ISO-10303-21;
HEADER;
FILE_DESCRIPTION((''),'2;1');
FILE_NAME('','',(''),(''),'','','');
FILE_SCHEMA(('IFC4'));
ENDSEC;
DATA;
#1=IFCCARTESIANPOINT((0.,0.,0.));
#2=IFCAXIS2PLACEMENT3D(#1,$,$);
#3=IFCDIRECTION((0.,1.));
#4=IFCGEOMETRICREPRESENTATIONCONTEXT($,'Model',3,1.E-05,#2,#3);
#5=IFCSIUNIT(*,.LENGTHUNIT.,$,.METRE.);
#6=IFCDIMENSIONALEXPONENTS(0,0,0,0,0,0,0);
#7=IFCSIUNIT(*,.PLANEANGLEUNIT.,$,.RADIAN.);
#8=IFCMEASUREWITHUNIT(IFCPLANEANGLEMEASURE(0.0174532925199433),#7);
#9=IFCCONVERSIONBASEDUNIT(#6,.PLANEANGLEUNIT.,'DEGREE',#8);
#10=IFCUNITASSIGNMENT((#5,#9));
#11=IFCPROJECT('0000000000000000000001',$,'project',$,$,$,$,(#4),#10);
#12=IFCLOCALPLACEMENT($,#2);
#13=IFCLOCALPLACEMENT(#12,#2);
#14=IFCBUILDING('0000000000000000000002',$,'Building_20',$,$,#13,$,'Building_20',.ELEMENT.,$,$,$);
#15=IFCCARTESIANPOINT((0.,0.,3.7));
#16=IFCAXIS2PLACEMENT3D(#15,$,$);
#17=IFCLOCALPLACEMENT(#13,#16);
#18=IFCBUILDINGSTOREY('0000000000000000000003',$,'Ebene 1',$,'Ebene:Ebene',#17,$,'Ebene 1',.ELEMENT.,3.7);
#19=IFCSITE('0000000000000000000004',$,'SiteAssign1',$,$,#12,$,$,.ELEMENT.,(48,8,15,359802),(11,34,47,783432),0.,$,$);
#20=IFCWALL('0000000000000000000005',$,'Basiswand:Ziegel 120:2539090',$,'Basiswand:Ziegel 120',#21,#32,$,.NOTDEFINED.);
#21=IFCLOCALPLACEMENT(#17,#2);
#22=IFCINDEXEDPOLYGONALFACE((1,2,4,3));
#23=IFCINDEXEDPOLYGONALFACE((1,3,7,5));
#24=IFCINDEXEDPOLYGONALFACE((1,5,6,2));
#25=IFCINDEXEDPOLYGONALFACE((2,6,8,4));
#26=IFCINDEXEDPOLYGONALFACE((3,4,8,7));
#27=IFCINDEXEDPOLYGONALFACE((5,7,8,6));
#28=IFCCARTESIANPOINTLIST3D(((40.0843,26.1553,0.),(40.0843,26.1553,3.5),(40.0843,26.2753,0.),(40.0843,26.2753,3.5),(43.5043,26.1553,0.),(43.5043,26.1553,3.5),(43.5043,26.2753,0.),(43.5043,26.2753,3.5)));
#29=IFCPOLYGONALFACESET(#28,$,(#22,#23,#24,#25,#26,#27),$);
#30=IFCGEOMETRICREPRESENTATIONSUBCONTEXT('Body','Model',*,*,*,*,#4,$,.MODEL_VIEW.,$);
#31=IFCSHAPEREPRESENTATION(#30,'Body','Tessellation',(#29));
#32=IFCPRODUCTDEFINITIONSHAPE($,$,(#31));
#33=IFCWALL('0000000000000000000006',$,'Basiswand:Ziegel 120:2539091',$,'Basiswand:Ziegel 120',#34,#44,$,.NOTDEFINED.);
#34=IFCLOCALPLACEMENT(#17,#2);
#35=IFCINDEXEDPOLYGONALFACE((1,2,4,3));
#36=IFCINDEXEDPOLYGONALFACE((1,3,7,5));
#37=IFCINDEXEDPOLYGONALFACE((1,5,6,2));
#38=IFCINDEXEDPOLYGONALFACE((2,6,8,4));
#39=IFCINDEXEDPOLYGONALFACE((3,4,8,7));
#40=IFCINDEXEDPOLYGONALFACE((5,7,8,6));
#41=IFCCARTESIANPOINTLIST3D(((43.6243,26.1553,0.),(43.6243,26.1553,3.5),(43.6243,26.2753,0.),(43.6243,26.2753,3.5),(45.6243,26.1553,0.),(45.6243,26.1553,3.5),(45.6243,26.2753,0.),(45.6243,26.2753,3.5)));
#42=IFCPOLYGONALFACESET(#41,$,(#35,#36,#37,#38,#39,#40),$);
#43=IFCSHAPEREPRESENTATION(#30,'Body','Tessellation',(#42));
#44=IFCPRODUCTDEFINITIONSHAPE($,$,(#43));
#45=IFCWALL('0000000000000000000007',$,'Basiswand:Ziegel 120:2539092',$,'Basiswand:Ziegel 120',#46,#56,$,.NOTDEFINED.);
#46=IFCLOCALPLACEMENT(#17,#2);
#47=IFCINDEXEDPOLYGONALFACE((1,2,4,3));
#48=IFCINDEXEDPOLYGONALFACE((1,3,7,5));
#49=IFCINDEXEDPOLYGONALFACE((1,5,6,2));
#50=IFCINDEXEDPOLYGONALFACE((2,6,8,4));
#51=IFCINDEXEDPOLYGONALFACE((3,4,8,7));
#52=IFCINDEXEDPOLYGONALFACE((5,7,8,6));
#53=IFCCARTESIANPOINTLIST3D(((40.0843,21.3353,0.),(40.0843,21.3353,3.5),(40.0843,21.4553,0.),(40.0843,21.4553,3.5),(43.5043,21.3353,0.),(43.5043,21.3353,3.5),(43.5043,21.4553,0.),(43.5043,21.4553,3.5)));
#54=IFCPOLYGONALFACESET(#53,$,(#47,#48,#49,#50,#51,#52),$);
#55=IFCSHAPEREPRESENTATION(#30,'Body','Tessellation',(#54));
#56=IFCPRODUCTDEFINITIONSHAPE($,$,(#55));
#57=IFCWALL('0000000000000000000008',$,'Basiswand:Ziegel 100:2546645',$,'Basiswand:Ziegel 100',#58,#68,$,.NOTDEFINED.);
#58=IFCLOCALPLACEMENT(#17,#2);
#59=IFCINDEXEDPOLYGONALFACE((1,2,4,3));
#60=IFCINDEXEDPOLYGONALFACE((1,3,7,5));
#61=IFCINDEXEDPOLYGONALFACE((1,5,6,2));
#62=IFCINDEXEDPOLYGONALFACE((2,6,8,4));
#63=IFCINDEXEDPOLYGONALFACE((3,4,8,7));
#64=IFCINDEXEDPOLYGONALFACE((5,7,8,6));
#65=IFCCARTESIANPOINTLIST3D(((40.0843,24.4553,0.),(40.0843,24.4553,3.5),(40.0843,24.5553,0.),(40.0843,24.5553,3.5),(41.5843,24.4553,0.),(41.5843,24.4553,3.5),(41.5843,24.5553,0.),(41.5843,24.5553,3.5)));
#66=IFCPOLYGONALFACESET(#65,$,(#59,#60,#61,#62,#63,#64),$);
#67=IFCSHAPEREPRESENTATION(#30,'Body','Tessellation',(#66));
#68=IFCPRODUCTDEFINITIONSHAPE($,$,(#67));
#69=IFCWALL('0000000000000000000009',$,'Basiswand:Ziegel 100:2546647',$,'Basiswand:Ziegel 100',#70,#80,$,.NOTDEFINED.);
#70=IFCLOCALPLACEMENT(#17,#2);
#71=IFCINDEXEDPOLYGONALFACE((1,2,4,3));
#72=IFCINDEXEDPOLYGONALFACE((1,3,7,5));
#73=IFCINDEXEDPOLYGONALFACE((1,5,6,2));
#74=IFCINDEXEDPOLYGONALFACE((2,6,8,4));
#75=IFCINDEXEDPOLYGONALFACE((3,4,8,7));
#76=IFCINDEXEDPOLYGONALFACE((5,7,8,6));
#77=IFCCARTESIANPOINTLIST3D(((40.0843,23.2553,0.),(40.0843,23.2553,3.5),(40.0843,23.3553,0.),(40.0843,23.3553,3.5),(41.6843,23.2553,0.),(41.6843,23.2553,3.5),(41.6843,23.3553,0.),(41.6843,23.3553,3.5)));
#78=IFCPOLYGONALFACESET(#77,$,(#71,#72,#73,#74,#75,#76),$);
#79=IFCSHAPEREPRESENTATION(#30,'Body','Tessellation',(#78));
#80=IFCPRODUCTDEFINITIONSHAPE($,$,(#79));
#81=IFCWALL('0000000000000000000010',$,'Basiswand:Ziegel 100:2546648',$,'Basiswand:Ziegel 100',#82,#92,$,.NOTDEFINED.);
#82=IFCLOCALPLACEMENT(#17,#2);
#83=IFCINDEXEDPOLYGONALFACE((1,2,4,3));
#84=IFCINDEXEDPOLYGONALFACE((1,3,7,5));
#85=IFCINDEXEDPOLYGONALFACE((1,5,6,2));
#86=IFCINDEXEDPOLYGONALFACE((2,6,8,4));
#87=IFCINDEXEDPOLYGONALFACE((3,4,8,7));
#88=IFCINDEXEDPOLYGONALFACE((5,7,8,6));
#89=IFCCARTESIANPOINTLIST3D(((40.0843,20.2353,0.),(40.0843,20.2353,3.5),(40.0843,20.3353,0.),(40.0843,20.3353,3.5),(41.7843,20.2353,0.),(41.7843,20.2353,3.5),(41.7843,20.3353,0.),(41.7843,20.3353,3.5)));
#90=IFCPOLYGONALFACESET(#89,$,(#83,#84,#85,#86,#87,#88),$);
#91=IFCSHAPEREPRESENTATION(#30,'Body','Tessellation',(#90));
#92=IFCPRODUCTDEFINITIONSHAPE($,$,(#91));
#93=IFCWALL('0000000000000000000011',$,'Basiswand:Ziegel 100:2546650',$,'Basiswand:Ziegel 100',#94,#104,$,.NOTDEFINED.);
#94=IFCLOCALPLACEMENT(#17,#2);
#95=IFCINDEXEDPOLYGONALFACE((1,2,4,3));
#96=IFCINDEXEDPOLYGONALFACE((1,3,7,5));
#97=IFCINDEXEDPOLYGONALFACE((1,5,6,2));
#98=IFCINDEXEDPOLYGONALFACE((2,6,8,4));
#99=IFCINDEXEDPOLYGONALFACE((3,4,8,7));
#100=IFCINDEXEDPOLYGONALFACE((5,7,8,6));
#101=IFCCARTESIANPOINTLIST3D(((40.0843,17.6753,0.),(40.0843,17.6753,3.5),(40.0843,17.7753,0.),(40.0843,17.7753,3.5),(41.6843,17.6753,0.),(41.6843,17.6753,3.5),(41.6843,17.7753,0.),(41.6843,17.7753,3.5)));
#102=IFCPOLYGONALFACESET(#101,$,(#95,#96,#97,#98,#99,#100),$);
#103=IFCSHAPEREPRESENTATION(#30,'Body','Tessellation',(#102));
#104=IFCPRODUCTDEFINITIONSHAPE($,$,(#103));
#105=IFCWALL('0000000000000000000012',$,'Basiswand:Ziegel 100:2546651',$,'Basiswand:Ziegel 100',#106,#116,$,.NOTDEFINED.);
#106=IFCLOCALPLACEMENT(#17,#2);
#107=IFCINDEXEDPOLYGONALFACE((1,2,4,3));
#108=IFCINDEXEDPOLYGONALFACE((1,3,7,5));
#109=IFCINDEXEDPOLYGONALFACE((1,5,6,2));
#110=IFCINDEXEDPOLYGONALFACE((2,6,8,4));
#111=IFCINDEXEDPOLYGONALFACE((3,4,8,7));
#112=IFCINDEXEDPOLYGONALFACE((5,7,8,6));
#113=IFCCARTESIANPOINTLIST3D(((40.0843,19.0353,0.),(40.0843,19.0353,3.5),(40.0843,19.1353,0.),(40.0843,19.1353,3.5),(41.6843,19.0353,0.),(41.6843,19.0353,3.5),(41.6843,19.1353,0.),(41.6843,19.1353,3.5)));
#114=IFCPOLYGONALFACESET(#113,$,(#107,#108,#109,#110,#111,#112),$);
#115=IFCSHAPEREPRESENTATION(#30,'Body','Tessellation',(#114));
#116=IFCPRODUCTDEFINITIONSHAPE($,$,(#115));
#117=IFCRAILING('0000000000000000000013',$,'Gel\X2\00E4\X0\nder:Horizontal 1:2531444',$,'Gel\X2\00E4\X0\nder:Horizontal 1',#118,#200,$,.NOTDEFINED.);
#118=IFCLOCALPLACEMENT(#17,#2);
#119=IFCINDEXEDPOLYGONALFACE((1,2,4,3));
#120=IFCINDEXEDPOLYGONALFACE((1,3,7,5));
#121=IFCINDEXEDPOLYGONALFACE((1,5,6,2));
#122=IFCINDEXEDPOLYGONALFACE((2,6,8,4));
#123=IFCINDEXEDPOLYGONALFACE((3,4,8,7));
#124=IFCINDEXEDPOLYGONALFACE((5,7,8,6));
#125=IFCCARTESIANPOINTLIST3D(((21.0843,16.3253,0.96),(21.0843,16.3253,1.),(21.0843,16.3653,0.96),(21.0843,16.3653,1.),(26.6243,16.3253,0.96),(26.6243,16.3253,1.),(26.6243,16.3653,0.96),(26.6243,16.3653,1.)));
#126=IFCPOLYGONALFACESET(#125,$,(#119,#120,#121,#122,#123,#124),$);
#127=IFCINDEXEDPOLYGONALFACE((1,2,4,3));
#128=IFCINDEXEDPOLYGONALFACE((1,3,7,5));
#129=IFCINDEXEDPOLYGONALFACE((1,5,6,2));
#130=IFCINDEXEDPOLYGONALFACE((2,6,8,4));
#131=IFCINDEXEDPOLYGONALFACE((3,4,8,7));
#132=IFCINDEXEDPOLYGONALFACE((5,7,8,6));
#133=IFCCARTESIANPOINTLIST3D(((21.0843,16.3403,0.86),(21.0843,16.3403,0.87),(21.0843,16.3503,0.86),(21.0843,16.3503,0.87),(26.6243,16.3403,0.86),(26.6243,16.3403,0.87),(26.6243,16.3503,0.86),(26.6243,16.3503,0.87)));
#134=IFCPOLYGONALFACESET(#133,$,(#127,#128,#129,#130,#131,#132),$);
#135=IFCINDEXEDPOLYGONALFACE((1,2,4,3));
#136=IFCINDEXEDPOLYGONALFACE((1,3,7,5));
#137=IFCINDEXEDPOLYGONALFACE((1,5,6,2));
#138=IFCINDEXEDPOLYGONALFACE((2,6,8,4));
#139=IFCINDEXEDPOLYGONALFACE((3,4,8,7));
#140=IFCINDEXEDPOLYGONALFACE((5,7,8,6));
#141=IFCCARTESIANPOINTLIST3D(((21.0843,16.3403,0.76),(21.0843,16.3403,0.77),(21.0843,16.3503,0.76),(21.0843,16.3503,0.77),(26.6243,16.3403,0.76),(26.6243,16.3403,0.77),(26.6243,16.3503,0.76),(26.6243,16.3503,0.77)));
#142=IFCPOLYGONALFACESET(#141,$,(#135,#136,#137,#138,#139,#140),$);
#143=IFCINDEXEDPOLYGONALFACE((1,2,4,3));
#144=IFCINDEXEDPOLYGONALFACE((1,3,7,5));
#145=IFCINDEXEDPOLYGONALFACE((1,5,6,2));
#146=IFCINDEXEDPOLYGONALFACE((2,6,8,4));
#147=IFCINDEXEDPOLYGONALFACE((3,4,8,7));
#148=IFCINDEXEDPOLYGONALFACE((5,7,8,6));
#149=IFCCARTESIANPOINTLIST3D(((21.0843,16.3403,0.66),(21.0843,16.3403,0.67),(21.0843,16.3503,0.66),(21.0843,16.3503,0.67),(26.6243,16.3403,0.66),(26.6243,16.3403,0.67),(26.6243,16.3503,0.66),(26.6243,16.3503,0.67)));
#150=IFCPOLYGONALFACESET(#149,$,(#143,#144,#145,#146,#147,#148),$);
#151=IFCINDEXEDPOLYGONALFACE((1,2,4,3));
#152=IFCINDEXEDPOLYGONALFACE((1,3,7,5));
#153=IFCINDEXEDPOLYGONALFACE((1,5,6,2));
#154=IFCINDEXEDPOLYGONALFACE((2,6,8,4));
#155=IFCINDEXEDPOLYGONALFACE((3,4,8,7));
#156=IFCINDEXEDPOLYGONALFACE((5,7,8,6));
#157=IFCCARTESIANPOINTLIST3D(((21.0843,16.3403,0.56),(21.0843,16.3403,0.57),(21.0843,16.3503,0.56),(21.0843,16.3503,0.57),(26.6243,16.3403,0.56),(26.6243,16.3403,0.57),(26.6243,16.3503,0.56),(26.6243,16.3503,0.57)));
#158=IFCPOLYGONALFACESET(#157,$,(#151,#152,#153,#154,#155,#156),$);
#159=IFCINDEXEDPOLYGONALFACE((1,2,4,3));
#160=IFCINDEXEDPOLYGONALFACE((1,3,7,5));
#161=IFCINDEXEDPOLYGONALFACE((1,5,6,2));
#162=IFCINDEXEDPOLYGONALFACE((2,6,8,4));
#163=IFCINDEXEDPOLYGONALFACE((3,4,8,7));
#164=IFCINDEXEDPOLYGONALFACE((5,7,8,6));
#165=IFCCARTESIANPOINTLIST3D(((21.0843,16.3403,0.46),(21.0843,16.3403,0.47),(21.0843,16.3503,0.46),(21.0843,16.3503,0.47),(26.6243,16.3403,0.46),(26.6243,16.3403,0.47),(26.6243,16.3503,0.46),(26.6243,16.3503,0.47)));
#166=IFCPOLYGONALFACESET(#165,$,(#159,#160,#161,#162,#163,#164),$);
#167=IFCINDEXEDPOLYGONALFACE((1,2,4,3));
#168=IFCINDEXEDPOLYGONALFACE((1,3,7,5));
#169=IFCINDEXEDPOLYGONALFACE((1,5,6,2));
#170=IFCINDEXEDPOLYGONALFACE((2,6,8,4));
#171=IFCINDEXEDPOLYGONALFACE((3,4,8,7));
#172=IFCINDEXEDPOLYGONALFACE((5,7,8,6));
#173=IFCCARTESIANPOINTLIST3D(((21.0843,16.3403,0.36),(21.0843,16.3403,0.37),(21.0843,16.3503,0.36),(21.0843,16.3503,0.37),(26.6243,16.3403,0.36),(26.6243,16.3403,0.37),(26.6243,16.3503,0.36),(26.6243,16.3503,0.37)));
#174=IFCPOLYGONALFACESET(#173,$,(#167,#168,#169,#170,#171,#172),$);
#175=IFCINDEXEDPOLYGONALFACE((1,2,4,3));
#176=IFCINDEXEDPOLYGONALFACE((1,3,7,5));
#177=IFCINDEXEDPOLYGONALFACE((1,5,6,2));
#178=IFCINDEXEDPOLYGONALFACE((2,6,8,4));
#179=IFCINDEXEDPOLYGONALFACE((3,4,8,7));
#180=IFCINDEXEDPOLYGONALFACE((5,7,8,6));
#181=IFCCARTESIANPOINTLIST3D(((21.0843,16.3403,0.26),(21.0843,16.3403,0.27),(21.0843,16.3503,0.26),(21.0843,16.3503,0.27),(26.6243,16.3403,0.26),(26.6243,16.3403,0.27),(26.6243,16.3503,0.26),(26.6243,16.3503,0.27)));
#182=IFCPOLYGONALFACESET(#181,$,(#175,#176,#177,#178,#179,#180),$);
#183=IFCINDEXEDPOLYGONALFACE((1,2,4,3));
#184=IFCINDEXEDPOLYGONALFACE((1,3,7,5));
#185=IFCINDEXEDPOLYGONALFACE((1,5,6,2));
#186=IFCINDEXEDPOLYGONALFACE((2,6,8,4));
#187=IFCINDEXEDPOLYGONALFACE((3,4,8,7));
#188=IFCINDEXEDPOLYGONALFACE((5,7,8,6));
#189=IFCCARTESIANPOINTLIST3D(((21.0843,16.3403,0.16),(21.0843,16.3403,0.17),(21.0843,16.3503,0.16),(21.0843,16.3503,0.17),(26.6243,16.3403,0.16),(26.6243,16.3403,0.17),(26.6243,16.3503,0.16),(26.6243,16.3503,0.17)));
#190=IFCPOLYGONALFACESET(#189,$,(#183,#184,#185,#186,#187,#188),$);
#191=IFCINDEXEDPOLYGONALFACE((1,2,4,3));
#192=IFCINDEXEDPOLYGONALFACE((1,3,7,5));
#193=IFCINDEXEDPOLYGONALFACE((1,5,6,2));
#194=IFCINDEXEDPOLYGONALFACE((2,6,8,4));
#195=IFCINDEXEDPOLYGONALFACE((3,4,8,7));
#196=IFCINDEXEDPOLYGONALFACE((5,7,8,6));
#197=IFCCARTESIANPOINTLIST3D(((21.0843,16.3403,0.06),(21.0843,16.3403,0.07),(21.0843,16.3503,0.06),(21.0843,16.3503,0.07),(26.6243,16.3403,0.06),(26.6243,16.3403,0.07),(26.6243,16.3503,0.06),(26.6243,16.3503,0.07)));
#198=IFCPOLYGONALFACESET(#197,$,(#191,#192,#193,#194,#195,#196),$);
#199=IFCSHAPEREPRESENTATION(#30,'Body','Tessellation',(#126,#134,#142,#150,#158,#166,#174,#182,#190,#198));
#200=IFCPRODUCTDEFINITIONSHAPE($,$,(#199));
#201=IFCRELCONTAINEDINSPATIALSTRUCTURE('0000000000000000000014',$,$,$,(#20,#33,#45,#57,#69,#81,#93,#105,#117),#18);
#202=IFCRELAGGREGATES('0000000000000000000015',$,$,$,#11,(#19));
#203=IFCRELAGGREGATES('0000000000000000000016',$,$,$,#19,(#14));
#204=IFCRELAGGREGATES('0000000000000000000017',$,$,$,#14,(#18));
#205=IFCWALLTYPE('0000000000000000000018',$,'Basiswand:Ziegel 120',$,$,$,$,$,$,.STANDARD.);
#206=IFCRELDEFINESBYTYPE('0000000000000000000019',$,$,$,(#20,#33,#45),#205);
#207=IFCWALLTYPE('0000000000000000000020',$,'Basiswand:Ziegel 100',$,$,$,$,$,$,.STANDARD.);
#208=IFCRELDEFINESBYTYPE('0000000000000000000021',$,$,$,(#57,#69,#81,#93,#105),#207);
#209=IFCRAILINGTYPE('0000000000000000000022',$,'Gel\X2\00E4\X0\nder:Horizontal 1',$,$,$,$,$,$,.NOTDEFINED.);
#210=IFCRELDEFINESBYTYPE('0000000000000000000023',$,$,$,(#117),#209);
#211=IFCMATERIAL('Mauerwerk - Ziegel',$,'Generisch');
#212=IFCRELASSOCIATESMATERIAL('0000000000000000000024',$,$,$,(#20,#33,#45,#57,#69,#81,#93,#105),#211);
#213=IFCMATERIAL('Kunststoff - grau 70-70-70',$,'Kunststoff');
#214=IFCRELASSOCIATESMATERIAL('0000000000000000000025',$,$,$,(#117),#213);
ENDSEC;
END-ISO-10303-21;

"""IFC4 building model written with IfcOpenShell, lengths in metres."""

from ifc_helpers import new_model, entity, si_unit, converted_unit, direction, frame, origin, place, context, subcontext, project, spatial, indexed_curve, outline, extrude, material, type_object, element, save


model = new_model("IFC4")

# Units and contexts
model_context = context("Model", 3, precision=1e-05, world=origin(), true_north=direction((0.0, 1.0)))
body_context = subcontext(model_context, "Body", "Model", "MODEL_VIEW")
ifc_project = project(units=[si_unit("LENGTHUNIT", "METRE"), converted_unit("PLANEANGLEUNIT", "DEGREE", entity("IfcPlaneAngleMeasure", 0.0174532925199433), si_unit("PLANEANGLEUNIT", "RADIAN"), dimensions=[0, 0, 0, 0, 0, 0, 0])], contexts=[model_context])

# Site, building, storey
site_placement = place(None, origin())
site = spatial("IfcSite", under=ifc_project, at=site_placement, Name="SiteAssign1", CompositionType="ELEMENT", RefLatitude=(48, 8, 15, 359802), RefLongitude=(11, 34, 47, 783432), RefElevation=0.0)
building_placement = place(site_placement, origin())
building = spatial("IfcBuilding", under=site, at=building_placement, Name="Building_20", LongName="Building_20", CompositionType="ELEMENT")
storey_placement = place(building_placement, frame((0.0, 0.0, 3.7)))
storey = spatial("IfcBuildingStorey", under=building, at=storey_placement, Name="Ebene 1", ObjectType="Ebene:Ebene", LongName="Ebene 1", CompositionType="ELEMENT", Elevation=3.7)

# Shared definitions
ifc_material_1 = material(Name="Mauerwerk - Ziegel", Category="Generisch")

# Walls
wall_type_1 = type_object("IfcWallType", Name="Basiswand:Ziegel 120", PredefinedType="STANDARD")
wall_1_placement = place(storey_placement, frame((43.5043, 26.2153, 0.0), z_axis=(0.0, 0.0, 1.0), x_axis=(-1.0, 0.0, 0.0)))
element("IfcWall", 1, at=wall_1_placement, inside=storey, type_object=wall_type_1, material=ifc_material_1, Name="Basiswand:Ziegel 120:2539090", ObjectType="Basiswand:Ziegel 120", PredefinedType="NOTDEFINED", context=body_context, shape_type="SweptSolid", body=[
    extrude(outline(indexed_curve([(3.42, 0.06), (0.0, 0.06), (0.0, -0.06), (3.42, -0.06), (3.42, 0.06)], self_intersect=False)), origin(), (0.0, 0.0, 1.0), 3.5),
])
wall_2_placement = place(storey_placement, frame((43.6243, 26.2153, 0.0)))
element("IfcWall", 2, at=wall_2_placement, inside=storey, type_object=wall_type_1, material=ifc_material_1, Name="Basiswand:Ziegel 120:2539091", ObjectType="Basiswand:Ziegel 120", PredefinedType="NOTDEFINED", context=body_context, shape_type="SweptSolid", body=[
    extrude(outline(indexed_curve([(2.0, 0.06), (0.0, 0.06), (0.0, -0.06), (2.0, -0.06), (2.0, 0.06)], self_intersect=False)), origin(), (0.0, 0.0, 1.0), 3.5),
])
wall_3_placement = place(storey_placement, frame((43.5043, 21.3953, 0.0), z_axis=(0.0, 0.0, 1.0), x_axis=(-1.0, 0.0, 0.0)))
element("IfcWall", 3, at=wall_3_placement, inside=storey, type_object=wall_type_1, material=ifc_material_1, Name="Basiswand:Ziegel 120:2539092", ObjectType="Basiswand:Ziegel 120", PredefinedType="NOTDEFINED", context=body_context, shape_type="SweptSolid", body=[
    extrude(outline(indexed_curve([(3.42, 0.06), (0.0, 0.06), (0.0, -0.06), (3.42, -0.06), (3.42, 0.06)], self_intersect=False)), origin(), (0.0, 0.0, 1.0), 3.5),
])
wall_type_2 = type_object("IfcWallType", Name="Basiswand:Ziegel 100", PredefinedType="STANDARD")
wall_4_placement = place(storey_placement, frame((40.0843, 24.5053, 0.0)))
element("IfcWall", 4, at=wall_4_placement, inside=storey, type_object=wall_type_2, material=ifc_material_1, Name="Basiswand:Ziegel 100:2546645", ObjectType="Basiswand:Ziegel 100", PredefinedType="NOTDEFINED", context=body_context, shape_type="SweptSolid", body=[
    extrude(outline(indexed_curve([(1.5, 0.05), (0.0, 0.05), (0.0, -0.05), (1.5, -0.05), (1.5, 0.05)], self_intersect=False)), origin(), (0.0, 0.0, 1.0), 3.5),
])
wall_5_placement = place(storey_placement, frame((40.0843, 23.3053, 0.0)))
element("IfcWall", 5, at=wall_5_placement, inside=storey, type_object=wall_type_2, material=ifc_material_1, Name="Basiswand:Ziegel 100:2546647", ObjectType="Basiswand:Ziegel 100", PredefinedType="NOTDEFINED", context=body_context, shape_type="SweptSolid", body=[
    extrude(outline(indexed_curve([(1.6, 0.05), (0.0, 0.05), (0.0, -0.05), (1.6, -0.05), (1.6, 0.05)], self_intersect=False)), origin(), (0.0, 0.0, 1.0), 3.5),
])
wall_6_placement = place(storey_placement, frame((40.0843, 20.2853, 0.0)))
element("IfcWall", 6, at=wall_6_placement, inside=storey, type_object=wall_type_2, material=ifc_material_1, Name="Basiswand:Ziegel 100:2546648", ObjectType="Basiswand:Ziegel 100", PredefinedType="NOTDEFINED", context=body_context, shape_type="SweptSolid", body=[
    extrude(outline(indexed_curve([(1.7, 0.05), (0.0, 0.05), (0.0, -0.05), (1.7, -0.05), (1.7, 0.05)], self_intersect=False)), origin(), (0.0, 0.0, 1.0), 3.5),
])
for number, where, name in (
    (7, (40.0843, 17.7253, 0.0), "Basiswand:Ziegel 100:2546650"),
    (8, (40.0843, 19.0853, 0.0), "Basiswand:Ziegel 100:2546651"),
):
    element("IfcWall", number, at=place(storey_placement, frame(where)), inside=storey, type_object=wall_type_2, material=ifc_material_1, Name=name, ObjectType="Basiswand:Ziegel 100", PredefinedType="NOTDEFINED", context=body_context, shape_type="SweptSolid", body=[
        extrude(outline(indexed_curve([(1.6, 0.05), (0.0, 0.05), (0.0, -0.05), (1.6, -0.05), (1.6, 0.05)], self_intersect=False)), origin(), (0.0, 0.0, 1.0), 3.5),
    ])

# Railing
ifc_material_2 = material(Name="Kunststoff - grau 70-70-70", Category="Kunststoff")
railing_type = type_object("IfcRailingType", Name="Geländer:Horizontal 1", PredefinedType="NOTDEFINED")
railing_placement = place(storey_placement, origin())
element("IfcRailing", 9, at=railing_placement, inside=storey, type_object=railing_type, material=ifc_material_2, Name="Geländer:Horizontal 1:2531444", ObjectType="Geländer:Horizontal 1", PredefinedType="NOTDEFINED", context=body_context, shape_type="SweptSolid", body=[
    extrude(outline(indexed_curve([(-2.77, -0.02), (2.77, -0.02), (2.77, 0.02), (-2.77, 0.02), (-2.77, -0.02)], self_intersect=False)), frame((23.8543, 16.3453, 0.96)), (0.0, 0.0, 1.0), 0.04),
    extrude(outline(indexed_curve([(-2.77, -0.005), (2.77, -0.005), (2.77, 0.005), (-2.77, 0.005), (-2.77, -0.005)], self_intersect=False)), frame((23.8543, 16.3453, 0.86)), (0.0, 0.0, 1.0), 0.01),
    extrude(outline(indexed_curve([(-2.77, -0.005), (2.77, -0.005), (2.77, 0.005), (-2.77, 0.005), (-2.77, -0.005)], self_intersect=False)), frame((23.8543, 16.3453, 0.76)), (0.0, 0.0, 1.0), 0.01),
    extrude(outline(indexed_curve([(-2.77, -0.005), (2.77, -0.005), (2.77, 0.005), (-2.77, 0.005), (-2.77, -0.005)], self_intersect=False)), frame((23.8543, 16.3453, 0.66)), (0.0, 0.0, 1.0), 0.01),
    extrude(outline(indexed_curve([(-2.77, -0.005), (2.77, -0.005), (2.77, 0.005), (-2.77, 0.005), (-2.77, -0.005)], self_intersect=False)), frame((23.8543, 16.3453, 0.56)), (0.0, 0.0, 1.0), 0.01),
    extrude(outline(indexed_curve([(-2.77, -0.005), (2.77, -0.005), (2.77, 0.005), (-2.77, 0.005), (-2.77, -0.005)], self_intersect=False)), frame((23.8543, 16.3453, 0.46)), (0.0, 0.0, 1.0), 0.01),
    extrude(outline(indexed_curve([(-2.77, -0.005), (2.77, -0.005), (2.77, 0.005), (-2.77, 0.005), (-2.77, -0.005)], self_intersect=False)), frame((23.8543, 16.3453, 0.36)), (0.0, 0.0, 1.0), 0.01),
    extrude(outline(indexed_curve([(-2.77, -0.005), (2.77, -0.005), (2.77, 0.005), (-2.77, 0.005), (-2.77, -0.005)], self_intersect=False)), frame((23.8543, 16.3453, 0.26)), (0.0, 0.0, 1.0), 0.01),
    extrude(outline(indexed_curve([(-2.77, -0.005), (2.77, -0.005), (2.77, 0.005), (-2.77, 0.005), (-2.77, -0.005)], self_intersect=False)), frame((23.8543, 16.3453, 0.16)), (0.0, 0.0, 1.0), 0.01),
    extrude(outline(indexed_curve([(-2.77, -0.005), (2.77, -0.005), (2.77, 0.005), (-2.77, 0.005), (-2.77, -0.005)], self_intersect=False)), frame((23.8543, 16.3453, 0.06)), (0.0, 0.0, 1.0), 0.01),
])

save(model, "model.ifc")
